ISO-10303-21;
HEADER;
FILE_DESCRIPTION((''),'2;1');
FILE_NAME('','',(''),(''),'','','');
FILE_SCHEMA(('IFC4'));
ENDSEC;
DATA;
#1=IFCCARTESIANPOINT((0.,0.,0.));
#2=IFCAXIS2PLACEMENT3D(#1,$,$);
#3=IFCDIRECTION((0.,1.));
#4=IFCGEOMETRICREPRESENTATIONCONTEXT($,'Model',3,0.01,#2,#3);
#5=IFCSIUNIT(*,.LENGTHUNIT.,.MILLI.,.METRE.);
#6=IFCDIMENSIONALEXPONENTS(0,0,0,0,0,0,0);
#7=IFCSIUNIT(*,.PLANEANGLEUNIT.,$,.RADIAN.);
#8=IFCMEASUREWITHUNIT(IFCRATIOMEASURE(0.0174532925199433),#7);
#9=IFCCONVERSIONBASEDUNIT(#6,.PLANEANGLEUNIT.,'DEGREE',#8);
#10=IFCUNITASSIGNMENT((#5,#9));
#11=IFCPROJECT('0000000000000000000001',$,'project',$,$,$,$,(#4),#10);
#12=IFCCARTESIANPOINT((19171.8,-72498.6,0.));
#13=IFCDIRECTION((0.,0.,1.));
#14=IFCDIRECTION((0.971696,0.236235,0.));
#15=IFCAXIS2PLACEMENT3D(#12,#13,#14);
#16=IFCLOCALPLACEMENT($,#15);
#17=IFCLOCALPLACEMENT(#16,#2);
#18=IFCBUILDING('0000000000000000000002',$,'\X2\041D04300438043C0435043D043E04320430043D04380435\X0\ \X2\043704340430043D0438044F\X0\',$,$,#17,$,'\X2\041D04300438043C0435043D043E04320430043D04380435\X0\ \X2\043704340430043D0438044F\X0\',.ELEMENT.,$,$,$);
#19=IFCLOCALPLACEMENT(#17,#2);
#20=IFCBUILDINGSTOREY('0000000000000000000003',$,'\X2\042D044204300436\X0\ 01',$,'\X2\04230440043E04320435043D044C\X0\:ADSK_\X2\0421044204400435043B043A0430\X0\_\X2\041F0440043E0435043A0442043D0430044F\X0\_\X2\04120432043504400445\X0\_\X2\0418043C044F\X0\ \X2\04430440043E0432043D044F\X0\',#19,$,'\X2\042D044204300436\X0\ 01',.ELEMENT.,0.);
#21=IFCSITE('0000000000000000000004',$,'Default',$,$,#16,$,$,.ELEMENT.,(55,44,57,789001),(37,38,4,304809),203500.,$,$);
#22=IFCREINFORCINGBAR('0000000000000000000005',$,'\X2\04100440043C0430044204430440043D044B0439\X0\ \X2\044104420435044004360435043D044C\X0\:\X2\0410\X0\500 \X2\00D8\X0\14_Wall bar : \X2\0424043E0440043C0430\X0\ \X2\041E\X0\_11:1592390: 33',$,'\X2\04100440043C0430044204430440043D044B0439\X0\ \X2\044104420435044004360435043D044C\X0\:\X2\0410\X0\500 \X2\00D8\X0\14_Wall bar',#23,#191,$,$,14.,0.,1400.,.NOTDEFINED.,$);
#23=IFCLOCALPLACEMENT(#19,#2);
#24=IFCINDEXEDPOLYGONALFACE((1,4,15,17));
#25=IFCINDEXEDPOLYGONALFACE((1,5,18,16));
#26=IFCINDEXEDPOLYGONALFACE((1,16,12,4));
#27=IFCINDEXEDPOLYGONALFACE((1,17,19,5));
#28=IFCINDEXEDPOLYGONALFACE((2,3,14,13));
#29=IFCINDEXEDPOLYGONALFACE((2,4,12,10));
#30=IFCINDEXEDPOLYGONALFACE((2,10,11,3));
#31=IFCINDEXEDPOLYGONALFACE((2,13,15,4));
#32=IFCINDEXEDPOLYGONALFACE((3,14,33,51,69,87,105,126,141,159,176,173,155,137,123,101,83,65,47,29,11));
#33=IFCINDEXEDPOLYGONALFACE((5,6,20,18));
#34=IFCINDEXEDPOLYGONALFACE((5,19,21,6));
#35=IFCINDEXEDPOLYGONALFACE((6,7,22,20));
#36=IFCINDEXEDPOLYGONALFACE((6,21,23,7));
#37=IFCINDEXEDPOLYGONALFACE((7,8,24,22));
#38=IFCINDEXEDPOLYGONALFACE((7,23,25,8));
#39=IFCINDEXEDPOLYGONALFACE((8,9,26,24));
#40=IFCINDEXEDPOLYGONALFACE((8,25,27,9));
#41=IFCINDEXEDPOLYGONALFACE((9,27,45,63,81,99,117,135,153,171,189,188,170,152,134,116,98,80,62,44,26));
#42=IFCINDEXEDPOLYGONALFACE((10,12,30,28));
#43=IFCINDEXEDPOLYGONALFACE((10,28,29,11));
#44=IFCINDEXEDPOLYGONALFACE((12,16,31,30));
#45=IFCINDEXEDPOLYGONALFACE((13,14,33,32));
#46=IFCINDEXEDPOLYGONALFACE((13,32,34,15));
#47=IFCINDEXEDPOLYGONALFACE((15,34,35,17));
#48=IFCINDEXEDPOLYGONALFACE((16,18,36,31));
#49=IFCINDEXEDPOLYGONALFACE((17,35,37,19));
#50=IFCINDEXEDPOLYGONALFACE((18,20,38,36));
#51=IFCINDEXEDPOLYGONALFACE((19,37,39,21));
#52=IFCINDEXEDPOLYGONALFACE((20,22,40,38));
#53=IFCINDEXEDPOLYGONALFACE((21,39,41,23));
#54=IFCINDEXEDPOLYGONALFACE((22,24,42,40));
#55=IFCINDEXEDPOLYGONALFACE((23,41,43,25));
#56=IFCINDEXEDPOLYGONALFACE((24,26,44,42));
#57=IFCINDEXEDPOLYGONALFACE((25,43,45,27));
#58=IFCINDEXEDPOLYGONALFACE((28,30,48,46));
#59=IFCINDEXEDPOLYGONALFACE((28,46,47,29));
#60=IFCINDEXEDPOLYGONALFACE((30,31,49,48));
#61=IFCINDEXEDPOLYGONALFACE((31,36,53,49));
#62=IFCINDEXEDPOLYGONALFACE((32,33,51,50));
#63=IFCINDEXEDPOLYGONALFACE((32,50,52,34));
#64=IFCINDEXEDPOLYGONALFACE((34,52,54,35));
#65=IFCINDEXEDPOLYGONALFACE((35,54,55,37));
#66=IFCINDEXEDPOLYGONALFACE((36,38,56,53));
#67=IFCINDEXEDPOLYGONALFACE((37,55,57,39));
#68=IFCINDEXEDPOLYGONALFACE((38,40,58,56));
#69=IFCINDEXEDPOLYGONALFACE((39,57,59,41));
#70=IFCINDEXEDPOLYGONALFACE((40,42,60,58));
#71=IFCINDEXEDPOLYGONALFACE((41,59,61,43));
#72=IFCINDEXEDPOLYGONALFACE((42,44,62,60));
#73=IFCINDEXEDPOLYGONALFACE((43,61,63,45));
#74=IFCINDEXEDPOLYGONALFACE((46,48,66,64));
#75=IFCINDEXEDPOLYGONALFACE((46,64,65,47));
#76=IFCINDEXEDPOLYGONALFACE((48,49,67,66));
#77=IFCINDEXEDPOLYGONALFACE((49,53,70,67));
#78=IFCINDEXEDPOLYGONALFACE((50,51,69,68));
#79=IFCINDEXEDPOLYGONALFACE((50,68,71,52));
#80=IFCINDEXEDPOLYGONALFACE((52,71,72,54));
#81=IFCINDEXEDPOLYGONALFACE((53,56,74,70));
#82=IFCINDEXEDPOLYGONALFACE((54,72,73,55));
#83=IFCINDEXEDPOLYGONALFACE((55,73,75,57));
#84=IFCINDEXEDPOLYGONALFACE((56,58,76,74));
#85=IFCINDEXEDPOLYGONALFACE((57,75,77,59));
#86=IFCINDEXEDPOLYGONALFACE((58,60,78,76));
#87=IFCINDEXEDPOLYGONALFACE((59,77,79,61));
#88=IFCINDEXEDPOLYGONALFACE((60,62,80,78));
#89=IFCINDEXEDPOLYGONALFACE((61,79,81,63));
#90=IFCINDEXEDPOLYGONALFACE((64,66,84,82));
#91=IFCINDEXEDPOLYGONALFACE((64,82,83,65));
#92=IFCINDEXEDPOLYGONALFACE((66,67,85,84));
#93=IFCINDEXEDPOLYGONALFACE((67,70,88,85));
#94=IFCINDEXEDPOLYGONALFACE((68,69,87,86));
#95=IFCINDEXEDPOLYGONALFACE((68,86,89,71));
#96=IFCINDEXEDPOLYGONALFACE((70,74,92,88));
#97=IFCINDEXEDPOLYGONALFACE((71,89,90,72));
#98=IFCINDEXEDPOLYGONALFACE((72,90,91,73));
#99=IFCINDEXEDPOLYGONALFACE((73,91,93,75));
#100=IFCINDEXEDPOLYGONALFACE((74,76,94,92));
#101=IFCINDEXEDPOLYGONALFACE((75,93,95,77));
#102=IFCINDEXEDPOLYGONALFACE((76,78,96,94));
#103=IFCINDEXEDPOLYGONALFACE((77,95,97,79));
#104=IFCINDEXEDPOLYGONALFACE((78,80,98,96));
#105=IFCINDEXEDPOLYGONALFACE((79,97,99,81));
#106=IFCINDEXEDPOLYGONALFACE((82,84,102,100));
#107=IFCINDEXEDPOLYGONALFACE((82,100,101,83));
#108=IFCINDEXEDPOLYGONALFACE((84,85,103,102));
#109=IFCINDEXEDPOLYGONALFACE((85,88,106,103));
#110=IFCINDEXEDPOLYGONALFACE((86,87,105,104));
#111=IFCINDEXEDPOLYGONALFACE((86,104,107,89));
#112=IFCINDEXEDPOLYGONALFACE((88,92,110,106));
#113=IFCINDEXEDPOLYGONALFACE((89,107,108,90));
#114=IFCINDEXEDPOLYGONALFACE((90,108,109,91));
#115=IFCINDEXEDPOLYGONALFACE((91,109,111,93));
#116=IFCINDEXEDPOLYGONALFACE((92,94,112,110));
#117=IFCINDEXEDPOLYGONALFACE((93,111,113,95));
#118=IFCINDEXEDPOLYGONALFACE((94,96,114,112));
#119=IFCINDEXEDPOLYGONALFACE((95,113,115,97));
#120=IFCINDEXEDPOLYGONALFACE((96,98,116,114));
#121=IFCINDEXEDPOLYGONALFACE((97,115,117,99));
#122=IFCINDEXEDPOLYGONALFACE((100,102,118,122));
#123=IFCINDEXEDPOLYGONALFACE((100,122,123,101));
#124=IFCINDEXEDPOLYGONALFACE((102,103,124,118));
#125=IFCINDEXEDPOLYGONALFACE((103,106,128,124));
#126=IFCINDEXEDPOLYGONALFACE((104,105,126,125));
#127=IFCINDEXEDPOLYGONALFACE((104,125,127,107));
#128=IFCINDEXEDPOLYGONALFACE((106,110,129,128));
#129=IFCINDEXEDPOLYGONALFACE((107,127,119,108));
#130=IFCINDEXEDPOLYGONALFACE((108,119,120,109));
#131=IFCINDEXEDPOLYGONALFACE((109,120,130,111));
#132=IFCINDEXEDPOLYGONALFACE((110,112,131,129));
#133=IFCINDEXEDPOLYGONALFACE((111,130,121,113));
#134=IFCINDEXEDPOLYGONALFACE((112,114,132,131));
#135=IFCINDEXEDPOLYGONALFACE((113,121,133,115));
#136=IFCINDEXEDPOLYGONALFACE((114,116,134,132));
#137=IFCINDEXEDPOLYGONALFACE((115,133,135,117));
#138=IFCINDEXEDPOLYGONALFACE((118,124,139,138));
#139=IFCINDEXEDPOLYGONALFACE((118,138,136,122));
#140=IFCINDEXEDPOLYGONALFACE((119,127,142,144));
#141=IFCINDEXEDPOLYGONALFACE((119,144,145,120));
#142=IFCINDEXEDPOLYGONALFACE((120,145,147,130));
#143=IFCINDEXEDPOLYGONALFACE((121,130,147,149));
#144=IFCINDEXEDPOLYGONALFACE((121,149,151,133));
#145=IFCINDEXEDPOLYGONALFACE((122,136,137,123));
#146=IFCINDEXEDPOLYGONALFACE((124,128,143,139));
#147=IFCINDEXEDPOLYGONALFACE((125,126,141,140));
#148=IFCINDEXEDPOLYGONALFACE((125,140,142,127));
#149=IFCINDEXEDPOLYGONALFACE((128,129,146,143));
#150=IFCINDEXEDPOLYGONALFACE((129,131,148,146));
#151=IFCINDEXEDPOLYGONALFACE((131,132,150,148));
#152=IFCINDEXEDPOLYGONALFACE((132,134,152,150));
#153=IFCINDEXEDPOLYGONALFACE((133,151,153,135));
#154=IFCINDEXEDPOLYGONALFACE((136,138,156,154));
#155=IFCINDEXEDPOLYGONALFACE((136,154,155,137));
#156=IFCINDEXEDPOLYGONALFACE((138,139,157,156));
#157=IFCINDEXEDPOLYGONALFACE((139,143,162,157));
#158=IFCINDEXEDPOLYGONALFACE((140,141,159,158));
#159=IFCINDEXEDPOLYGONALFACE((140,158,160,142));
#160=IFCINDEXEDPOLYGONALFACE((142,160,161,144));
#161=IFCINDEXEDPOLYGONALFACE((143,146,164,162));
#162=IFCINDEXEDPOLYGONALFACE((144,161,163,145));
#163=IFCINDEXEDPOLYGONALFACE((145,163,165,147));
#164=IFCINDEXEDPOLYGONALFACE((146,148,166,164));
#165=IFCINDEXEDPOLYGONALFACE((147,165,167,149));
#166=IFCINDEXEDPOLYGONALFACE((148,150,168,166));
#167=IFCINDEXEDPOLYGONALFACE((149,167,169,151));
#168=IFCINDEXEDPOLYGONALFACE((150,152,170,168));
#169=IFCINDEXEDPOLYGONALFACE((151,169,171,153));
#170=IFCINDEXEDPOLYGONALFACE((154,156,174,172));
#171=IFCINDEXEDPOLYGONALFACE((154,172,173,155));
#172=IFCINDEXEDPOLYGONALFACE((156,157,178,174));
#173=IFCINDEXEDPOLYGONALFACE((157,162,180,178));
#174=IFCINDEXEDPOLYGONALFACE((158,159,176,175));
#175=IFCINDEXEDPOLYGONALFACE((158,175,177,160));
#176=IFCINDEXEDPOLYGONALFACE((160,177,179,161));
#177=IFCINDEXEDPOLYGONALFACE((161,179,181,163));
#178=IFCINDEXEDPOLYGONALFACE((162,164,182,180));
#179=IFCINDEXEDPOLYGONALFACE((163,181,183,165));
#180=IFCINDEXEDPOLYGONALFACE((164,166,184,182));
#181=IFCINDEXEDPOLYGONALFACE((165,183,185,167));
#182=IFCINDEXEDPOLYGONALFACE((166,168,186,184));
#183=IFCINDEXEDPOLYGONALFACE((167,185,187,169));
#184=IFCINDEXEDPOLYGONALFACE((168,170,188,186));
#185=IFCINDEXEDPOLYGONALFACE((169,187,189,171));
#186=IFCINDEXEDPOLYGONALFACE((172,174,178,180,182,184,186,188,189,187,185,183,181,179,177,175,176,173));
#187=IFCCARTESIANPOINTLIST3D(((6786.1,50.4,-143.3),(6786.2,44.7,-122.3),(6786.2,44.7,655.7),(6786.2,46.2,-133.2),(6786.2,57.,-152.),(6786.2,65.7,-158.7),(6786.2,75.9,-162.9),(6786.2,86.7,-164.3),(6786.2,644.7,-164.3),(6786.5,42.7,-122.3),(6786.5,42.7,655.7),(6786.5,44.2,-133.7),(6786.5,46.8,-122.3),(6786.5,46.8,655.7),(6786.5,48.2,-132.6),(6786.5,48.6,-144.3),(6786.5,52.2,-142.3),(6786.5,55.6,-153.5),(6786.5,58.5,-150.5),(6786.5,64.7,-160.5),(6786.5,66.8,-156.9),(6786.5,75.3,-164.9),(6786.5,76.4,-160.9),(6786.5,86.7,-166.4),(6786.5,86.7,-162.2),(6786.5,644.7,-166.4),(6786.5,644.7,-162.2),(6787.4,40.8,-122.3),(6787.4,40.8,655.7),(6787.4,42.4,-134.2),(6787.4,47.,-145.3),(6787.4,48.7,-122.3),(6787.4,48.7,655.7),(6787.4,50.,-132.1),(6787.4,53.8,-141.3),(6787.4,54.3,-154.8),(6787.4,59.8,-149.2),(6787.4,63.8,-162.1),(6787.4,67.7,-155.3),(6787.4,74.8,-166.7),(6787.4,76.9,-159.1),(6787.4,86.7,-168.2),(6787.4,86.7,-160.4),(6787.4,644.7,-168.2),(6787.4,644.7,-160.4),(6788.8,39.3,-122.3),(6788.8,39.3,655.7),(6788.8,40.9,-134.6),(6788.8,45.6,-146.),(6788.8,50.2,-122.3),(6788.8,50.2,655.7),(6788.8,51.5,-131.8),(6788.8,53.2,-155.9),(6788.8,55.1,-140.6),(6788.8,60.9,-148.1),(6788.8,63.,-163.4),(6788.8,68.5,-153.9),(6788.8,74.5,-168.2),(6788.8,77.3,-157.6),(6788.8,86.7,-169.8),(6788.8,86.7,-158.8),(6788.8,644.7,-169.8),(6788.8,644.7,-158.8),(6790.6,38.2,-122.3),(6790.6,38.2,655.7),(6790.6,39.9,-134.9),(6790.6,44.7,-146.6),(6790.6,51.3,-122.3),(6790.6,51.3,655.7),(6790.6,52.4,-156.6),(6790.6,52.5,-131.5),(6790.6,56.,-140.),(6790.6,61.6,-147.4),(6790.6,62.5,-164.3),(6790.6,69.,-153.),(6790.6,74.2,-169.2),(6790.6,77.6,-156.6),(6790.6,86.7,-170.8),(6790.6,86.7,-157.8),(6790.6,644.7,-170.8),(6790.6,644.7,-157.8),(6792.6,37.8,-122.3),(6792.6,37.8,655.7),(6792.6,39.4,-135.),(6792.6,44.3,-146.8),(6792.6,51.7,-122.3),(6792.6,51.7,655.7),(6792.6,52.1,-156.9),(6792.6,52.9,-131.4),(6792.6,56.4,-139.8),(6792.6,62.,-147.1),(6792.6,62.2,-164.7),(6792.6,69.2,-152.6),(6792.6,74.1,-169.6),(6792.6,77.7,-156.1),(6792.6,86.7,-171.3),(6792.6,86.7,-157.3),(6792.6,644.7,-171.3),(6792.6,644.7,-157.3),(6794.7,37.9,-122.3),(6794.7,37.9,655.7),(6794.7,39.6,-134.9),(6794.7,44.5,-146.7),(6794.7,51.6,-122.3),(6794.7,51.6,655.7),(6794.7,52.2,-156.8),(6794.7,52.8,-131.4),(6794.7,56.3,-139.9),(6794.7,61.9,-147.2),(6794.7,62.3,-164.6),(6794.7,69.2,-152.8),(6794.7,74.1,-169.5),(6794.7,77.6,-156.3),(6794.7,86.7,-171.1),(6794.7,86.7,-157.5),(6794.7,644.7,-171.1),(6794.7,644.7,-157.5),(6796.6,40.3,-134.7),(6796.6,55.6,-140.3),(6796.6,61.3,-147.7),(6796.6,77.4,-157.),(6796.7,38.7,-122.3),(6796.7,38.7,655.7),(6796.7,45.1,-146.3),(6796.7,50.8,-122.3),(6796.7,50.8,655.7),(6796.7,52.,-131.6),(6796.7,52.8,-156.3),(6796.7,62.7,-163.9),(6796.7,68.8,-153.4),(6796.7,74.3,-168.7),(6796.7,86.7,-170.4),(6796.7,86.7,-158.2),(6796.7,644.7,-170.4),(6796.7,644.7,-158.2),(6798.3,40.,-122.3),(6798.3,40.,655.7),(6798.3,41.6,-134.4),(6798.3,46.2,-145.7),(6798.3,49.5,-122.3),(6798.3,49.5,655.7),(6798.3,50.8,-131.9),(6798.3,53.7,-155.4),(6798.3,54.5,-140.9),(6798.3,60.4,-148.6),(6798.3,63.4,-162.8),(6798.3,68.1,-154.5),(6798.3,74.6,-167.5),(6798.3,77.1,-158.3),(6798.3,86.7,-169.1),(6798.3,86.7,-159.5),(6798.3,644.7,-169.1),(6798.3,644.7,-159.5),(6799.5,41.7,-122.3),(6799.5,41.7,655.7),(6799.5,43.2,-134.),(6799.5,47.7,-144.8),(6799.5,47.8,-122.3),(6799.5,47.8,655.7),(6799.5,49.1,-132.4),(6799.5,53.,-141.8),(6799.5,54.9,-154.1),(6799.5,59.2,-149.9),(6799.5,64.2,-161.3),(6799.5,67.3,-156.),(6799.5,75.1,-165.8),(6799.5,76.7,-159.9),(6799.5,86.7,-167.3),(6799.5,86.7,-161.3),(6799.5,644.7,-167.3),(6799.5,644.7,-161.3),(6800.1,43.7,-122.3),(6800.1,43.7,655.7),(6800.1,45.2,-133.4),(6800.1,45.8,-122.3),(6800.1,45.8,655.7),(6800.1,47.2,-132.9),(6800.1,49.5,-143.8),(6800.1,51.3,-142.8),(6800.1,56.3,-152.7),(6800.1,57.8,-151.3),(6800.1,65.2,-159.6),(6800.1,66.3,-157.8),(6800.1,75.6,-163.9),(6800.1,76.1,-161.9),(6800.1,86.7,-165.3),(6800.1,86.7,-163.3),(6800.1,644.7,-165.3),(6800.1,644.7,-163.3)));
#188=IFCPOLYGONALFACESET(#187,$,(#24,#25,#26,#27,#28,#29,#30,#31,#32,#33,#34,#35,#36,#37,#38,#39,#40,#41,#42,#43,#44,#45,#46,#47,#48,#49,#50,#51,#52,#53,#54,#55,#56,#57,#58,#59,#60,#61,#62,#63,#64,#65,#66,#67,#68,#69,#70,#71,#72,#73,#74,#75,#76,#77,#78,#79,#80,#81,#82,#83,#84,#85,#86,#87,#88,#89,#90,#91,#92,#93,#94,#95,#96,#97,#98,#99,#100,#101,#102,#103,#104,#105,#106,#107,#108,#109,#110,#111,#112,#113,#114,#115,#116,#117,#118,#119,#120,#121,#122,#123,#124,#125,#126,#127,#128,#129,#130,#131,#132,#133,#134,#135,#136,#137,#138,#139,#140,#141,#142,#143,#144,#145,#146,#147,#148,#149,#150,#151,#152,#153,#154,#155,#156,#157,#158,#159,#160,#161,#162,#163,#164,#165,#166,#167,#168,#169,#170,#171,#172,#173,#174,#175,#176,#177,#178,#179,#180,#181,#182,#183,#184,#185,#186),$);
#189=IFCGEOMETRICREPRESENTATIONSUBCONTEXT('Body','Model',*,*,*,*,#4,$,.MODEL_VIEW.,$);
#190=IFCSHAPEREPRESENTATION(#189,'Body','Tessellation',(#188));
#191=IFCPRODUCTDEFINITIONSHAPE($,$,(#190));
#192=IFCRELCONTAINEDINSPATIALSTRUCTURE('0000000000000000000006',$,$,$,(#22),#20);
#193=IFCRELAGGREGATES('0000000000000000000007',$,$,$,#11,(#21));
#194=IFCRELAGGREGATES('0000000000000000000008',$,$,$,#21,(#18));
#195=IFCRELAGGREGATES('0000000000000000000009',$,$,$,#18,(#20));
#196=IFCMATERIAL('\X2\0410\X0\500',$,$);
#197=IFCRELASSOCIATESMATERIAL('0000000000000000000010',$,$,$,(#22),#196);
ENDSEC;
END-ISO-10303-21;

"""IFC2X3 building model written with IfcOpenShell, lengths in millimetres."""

from ifc_helpers import new_model, entity, si_unit, converted_unit, direction, frame, origin, place, context, subcontext, project, spatial, material, element, save


model = new_model("IFC2X3")

# Units and contexts
model_context = context("Model", 3, precision=0.01, world=origin(), true_north=direction((0.0, 1.0)))
body_context = subcontext(model_context, "Body", "Model", "MODEL_VIEW")
ifc_project = project(units=[si_unit("LENGTHUNIT", "METRE", prefix="MILLI"), converted_unit("PLANEANGLEUNIT", "DEGREE", entity("IfcRatioMeasure", 0.0174532925199433), si_unit("PLANEANGLEUNIT", "RADIAN"), dimensions=[0, 0, 0, 0, 0, 0, 0])], contexts=[model_context])

# Site, building, storey
site_placement = place(None, frame((19171.8, -72498.6, 0.0), z_axis=(0.0, 0.0, 1.0), x_axis=(0.971696, 0.236235, 0.0)))
site = spatial("IfcSite", under=ifc_project, at=site_placement, Name="Default", CompositionType="ELEMENT", RefLatitude=(55, 44, 57, 789001), RefLongitude=(37, 38, 4, 304809), RefElevation=203500.0)
building_placement = place(site_placement, origin())
building = spatial("IfcBuilding", under=site, at=building_placement, Name="Наименование здания", LongName="Наименование здания", CompositionType="ELEMENT")
storey_placement = place(building_placement, origin())
storey = spatial("IfcBuildingStorey", under=building, at=storey_placement, Name="Этаж 01", ObjectType="Уровень:ADSK_Стрелка_Проектная_Вверх_Имя уровня", LongName="Этаж 01", CompositionType="ELEMENT", Elevation=0.0)

# Reinforcing bar
ifc_material = material(Name="А500")
placement = place(storey_placement, origin())
element("IfcReinforcingBar", 1, at=placement, inside=storey, material=ifc_material, Name="Арматурный стержень:А500 Ø14_Wall bar : Форма О_11:1592390: 33", ObjectType="Арматурный стержень:А500 Ø14_Wall bar", BarLength=1400.0, BarRole="NOTDEFINED", CrossSectionArea=0.0, NominalDiameter=14.0, context=body_context, shape_type="AdvancedSweptSolid", body=[
    entity("IfcSweptDiskSolid", entity("IfcCompositeCurve", [entity("IfcCompositeCurveSegment", "CONTINUOUS", True, entity("IfcPolyline", [entity("IfcCartesianPoint", [6793.1, 44.7, 655.7]), entity("IfcCartesianPoint", [6793.1, 44.7, -122.3])])), entity("IfcCompositeCurveSegment", "CONTINUOUS", True, entity("IfcTrimmedCurve", entity("IfcCircle", entity("IfcAxis2Placement3D", entity("IfcCartesianPoint", [6793.1, 86.7, -122.3]), entity("IfcDirection", [1.0, 0.0, 0.0]), entity("IfcDirection", [0.0, 0.0, -1.0])), 42.0), [entity("IfcParameterValue", 270.0)], [entity("IfcParameterValue", 360.0)], True, "PARAMETER")), entity("IfcCompositeCurveSegment", "CONTINUOUS", True, entity("IfcPolyline", [entity("IfcCartesianPoint", [6793.1, 86.7, -164.3]), entity("IfcCartesianPoint", [6793.1, 644.7, -164.3])]))], False), 7.0, None, 0.0, 92.0),
])

save(model, "model.ifc")
